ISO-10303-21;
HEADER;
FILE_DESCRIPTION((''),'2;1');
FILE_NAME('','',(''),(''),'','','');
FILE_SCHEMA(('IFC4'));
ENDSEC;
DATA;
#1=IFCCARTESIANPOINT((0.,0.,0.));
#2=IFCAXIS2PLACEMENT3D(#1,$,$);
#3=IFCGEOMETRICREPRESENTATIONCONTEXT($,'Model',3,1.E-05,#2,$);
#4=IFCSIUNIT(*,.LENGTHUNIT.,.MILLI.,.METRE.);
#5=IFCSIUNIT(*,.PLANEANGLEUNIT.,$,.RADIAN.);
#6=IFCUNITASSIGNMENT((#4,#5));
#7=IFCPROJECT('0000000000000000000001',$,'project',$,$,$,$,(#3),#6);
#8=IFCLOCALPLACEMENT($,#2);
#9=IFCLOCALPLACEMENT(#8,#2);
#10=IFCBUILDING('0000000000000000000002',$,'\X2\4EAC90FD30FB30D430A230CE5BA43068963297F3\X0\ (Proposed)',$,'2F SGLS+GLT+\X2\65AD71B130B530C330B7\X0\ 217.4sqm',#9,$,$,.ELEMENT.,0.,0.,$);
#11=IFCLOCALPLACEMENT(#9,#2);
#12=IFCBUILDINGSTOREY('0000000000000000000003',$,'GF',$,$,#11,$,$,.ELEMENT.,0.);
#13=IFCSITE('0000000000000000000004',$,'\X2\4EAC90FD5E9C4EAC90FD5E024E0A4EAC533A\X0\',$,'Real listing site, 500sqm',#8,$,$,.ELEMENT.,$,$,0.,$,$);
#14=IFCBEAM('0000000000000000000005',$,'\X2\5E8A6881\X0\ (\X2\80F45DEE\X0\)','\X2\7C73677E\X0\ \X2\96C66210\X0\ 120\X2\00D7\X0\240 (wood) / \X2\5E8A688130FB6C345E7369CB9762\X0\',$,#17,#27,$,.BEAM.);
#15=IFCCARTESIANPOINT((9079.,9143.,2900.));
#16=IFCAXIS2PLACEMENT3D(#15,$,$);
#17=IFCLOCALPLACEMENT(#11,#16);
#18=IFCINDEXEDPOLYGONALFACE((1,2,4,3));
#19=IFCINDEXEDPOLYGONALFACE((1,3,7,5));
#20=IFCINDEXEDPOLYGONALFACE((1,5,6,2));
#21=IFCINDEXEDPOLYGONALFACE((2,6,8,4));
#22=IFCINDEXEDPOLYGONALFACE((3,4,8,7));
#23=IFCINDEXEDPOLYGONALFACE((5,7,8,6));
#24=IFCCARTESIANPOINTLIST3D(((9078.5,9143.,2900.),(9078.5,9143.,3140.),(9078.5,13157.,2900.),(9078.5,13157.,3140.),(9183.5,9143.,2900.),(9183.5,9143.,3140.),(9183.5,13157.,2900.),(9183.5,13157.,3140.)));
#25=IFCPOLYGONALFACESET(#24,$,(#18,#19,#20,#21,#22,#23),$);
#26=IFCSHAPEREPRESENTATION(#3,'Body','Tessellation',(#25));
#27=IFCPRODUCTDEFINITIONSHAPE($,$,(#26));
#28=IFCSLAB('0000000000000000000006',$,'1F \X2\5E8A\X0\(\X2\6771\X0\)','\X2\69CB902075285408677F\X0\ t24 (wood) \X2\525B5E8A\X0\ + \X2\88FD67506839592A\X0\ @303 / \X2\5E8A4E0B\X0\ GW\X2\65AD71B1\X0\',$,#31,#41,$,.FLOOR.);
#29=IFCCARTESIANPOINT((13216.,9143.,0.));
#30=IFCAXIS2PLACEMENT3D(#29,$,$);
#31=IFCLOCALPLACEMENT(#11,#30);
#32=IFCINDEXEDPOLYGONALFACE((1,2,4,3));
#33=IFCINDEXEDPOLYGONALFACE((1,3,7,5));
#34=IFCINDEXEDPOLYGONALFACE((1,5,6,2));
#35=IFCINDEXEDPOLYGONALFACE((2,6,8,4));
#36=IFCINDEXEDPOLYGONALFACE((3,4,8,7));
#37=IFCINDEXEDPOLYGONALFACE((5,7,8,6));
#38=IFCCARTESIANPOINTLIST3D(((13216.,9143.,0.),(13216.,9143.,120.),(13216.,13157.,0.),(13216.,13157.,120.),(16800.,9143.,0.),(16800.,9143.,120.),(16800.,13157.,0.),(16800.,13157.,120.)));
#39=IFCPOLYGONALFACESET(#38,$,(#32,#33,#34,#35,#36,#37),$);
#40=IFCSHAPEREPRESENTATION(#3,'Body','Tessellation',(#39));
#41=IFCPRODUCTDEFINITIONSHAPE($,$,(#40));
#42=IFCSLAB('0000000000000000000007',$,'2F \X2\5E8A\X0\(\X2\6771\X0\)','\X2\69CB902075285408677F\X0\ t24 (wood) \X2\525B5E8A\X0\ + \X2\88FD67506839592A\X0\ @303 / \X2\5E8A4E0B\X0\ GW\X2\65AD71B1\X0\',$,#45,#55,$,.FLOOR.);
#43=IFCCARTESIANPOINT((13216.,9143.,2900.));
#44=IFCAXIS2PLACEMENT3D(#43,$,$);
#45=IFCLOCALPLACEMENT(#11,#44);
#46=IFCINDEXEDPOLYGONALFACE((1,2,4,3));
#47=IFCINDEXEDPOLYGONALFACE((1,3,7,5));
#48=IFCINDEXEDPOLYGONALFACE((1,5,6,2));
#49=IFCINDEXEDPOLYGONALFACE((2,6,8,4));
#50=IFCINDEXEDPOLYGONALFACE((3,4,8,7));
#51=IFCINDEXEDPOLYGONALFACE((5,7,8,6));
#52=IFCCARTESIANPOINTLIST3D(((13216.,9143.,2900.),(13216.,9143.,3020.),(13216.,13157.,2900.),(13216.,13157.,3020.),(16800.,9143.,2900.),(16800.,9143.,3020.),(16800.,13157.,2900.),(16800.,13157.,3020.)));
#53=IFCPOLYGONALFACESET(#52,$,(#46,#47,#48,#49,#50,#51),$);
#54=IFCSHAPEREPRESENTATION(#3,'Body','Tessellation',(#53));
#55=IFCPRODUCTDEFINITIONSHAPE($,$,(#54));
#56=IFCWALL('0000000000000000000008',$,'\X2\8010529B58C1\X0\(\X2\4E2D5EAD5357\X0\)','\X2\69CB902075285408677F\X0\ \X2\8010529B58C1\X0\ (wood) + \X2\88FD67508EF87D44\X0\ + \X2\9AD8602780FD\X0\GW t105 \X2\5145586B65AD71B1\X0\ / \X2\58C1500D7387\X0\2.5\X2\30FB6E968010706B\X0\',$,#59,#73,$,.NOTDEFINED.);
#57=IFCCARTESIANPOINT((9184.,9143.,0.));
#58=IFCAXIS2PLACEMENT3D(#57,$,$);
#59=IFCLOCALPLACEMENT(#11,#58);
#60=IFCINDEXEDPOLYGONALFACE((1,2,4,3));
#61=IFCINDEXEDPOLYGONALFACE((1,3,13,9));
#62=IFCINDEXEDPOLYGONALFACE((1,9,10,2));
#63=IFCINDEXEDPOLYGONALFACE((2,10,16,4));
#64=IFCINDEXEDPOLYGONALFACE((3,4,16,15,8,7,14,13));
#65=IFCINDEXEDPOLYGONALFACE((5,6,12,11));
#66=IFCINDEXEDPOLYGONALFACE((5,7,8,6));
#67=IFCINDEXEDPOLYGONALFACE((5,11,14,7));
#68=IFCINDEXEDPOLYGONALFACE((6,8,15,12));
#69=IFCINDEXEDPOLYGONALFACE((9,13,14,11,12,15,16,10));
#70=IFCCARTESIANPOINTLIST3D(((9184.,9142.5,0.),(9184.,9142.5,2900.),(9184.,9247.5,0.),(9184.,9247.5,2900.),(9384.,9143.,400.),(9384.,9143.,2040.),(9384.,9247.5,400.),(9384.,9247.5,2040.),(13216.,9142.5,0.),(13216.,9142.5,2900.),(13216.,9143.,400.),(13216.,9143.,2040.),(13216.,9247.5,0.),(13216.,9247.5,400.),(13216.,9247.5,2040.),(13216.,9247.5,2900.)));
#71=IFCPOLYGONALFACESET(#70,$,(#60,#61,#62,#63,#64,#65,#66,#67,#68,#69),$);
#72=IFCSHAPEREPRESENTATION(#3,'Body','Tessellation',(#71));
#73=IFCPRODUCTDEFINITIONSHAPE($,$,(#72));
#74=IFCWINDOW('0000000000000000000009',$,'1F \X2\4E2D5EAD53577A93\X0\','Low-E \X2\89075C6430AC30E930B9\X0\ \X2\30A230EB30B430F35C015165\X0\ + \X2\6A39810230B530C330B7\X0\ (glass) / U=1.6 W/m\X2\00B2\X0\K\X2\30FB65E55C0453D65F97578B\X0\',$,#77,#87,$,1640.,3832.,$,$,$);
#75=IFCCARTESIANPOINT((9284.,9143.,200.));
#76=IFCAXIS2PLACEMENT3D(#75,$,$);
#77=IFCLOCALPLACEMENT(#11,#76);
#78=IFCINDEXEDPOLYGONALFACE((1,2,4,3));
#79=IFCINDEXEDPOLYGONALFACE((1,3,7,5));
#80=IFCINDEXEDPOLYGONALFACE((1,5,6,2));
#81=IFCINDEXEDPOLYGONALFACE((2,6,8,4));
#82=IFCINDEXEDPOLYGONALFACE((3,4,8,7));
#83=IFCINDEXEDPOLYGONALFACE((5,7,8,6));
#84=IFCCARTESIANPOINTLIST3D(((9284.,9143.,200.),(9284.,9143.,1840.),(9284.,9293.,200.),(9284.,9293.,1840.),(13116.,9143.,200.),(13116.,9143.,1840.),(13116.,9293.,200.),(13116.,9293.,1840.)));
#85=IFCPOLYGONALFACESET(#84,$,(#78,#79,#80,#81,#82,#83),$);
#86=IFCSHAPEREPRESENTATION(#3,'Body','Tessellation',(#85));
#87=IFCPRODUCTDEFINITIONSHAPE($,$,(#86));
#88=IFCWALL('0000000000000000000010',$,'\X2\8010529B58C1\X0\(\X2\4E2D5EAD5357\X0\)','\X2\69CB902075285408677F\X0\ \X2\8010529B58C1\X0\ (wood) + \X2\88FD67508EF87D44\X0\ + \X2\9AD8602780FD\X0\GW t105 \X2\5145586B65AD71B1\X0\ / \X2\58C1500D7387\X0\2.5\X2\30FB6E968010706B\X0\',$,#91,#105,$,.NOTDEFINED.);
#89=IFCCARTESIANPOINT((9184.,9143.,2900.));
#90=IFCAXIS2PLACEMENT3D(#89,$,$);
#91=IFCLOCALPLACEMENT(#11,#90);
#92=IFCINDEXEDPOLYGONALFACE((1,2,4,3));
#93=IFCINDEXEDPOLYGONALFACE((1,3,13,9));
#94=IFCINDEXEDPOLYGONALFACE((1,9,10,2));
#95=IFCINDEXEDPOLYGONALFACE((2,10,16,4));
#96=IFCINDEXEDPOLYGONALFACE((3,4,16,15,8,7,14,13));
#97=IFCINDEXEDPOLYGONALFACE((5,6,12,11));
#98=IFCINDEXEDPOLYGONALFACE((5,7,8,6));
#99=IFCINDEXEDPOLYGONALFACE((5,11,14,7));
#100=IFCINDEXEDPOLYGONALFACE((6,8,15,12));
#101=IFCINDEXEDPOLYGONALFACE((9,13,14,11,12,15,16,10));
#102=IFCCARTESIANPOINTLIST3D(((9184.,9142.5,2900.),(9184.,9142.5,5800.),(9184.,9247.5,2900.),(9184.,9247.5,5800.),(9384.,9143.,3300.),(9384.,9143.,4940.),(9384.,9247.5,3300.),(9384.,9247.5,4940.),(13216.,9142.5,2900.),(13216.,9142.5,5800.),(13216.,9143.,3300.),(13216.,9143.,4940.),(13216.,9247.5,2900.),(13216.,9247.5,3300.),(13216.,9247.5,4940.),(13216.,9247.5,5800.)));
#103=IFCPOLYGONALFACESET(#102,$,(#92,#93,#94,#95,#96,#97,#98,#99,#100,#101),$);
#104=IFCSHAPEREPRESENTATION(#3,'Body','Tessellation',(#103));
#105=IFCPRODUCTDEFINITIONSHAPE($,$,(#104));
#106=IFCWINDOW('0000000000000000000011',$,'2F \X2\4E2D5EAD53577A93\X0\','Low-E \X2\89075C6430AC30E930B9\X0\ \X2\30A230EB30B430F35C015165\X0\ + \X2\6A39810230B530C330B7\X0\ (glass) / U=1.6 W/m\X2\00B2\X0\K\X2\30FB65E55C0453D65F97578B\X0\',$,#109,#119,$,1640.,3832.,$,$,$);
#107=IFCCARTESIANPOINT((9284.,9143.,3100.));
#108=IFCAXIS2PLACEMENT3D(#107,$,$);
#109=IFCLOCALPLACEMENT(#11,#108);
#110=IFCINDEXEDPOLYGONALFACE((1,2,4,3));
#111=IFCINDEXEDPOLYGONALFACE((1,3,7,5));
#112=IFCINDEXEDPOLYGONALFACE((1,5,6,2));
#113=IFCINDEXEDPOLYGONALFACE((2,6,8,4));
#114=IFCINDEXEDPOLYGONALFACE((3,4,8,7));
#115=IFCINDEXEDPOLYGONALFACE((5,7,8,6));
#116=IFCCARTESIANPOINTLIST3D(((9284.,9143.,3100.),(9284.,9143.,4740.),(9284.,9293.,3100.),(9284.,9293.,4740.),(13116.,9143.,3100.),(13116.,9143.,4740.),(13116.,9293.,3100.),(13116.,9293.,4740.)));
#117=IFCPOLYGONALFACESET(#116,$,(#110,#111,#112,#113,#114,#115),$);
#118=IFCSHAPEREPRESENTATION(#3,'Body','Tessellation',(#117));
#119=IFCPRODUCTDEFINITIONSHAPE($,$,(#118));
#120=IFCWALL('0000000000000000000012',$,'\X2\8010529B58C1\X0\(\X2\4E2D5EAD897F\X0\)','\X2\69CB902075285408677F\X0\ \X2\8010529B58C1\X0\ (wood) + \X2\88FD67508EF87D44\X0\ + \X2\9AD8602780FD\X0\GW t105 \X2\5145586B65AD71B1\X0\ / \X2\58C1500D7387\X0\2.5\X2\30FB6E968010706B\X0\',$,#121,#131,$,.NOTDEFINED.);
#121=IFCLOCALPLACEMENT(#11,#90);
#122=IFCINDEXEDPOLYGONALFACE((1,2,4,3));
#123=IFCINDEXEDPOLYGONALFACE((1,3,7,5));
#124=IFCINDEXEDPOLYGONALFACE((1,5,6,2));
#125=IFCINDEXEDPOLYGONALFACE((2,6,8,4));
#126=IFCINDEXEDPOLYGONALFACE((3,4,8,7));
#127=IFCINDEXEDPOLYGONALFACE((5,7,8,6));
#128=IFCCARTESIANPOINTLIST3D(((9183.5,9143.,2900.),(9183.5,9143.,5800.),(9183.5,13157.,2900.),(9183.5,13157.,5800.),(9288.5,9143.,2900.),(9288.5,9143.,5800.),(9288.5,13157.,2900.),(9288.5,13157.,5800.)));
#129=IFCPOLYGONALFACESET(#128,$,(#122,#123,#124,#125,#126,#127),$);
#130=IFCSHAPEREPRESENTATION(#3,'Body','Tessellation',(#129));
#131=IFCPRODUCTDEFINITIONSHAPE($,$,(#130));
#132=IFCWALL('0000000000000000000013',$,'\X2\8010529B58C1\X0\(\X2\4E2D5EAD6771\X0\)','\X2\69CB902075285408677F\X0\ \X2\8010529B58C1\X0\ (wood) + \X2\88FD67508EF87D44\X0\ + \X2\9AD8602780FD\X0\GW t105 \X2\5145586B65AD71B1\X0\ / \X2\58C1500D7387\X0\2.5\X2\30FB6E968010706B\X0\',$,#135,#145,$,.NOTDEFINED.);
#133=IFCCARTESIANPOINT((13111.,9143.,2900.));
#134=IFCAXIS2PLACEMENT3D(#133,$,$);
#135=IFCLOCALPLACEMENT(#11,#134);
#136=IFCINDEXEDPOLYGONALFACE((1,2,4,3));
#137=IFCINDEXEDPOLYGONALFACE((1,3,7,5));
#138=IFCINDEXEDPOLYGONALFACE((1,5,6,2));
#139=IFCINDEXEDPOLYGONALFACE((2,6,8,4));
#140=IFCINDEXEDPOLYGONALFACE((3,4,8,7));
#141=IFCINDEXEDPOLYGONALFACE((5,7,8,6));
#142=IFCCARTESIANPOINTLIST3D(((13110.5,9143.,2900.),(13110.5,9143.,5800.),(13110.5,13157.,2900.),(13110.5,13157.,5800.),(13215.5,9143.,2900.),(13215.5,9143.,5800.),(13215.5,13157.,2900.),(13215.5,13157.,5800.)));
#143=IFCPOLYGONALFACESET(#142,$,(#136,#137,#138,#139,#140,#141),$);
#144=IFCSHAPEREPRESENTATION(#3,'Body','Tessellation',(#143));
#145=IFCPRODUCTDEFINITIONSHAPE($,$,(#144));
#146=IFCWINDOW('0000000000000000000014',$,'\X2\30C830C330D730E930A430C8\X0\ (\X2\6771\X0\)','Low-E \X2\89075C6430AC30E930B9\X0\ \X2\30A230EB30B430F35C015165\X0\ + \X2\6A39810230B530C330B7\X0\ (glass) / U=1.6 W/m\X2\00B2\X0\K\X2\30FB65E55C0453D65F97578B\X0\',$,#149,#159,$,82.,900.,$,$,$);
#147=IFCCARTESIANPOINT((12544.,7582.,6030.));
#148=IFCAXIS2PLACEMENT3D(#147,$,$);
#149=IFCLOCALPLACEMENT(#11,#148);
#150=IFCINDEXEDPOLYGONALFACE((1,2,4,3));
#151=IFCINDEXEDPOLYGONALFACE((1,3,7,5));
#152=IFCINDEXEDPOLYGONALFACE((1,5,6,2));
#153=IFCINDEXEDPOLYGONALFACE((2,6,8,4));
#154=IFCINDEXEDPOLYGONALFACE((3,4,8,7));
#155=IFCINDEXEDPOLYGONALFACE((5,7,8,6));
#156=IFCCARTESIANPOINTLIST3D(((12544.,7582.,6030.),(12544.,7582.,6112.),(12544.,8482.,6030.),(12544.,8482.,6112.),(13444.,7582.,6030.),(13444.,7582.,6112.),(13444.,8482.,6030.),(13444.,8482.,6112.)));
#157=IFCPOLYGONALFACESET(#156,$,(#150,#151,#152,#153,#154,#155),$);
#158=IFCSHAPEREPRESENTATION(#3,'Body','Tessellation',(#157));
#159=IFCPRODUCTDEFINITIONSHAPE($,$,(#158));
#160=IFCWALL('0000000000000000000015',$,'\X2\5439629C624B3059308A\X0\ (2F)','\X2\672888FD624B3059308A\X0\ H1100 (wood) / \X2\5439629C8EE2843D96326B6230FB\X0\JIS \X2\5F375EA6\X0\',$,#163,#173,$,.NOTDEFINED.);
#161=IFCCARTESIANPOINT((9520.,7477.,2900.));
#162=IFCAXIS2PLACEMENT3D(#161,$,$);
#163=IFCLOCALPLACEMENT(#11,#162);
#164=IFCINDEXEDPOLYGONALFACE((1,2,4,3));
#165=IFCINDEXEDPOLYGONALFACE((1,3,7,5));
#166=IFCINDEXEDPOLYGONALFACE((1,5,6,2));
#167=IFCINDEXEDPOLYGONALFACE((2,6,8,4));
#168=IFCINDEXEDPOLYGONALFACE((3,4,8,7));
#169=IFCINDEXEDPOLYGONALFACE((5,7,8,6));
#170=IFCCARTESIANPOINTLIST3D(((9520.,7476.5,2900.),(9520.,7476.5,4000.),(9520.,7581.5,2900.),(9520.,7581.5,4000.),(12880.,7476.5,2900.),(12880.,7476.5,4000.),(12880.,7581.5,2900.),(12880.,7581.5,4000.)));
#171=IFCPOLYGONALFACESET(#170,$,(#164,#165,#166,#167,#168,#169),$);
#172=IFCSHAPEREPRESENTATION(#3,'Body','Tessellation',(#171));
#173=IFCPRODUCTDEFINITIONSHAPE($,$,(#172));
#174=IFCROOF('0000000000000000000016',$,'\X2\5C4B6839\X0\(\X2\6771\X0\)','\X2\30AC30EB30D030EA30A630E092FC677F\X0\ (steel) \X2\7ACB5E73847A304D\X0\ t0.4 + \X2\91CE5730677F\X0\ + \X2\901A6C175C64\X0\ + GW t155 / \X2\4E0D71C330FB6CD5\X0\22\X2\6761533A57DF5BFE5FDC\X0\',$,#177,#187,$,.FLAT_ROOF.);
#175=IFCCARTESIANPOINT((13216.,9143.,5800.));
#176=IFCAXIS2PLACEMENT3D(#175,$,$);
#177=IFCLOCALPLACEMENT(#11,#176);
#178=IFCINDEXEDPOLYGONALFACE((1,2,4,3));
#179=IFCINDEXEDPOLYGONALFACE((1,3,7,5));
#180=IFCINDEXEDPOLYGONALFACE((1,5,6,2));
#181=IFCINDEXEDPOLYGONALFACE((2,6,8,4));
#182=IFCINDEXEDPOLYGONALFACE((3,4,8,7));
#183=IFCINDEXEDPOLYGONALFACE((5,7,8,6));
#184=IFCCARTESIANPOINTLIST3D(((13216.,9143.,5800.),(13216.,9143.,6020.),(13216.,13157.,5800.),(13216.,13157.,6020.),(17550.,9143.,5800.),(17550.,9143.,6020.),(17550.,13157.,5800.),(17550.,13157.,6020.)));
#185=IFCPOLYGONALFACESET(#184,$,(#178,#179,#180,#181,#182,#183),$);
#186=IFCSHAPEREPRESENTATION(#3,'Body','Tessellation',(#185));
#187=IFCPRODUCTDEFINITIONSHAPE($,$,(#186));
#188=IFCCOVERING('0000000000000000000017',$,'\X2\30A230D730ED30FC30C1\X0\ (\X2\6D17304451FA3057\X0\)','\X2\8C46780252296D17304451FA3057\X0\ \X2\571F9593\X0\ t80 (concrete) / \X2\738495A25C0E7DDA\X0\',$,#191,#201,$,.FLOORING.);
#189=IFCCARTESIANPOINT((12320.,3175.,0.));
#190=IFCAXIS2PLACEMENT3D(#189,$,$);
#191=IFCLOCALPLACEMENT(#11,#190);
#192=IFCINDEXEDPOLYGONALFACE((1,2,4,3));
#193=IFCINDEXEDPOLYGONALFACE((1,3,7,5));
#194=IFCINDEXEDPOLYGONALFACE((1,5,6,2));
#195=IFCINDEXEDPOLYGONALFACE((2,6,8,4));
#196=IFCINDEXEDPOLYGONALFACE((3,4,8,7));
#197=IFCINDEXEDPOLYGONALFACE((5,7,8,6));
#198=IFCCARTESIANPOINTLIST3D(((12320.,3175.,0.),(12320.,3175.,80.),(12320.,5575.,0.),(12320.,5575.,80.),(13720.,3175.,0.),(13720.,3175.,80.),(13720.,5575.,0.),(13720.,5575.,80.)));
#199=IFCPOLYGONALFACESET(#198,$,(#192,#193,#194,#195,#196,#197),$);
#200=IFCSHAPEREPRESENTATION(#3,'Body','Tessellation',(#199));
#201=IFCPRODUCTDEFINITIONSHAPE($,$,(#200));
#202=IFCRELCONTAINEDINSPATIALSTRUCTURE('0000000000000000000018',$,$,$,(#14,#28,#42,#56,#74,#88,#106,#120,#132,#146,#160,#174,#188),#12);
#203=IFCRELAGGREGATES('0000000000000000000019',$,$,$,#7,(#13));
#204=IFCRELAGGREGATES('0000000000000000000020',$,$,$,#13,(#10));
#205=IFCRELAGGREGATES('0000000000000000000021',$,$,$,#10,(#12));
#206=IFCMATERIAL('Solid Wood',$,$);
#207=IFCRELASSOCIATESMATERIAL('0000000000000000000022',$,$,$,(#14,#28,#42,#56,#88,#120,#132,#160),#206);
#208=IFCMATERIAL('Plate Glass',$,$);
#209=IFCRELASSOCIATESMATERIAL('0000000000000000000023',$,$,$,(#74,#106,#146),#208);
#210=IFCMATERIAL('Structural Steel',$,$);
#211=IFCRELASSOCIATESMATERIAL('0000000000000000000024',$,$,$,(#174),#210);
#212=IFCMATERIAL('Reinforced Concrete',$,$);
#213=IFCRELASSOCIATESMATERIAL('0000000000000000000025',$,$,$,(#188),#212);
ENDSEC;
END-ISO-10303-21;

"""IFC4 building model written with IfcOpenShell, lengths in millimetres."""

from ifc_helpers import new_model, si_unit, frame, frame_2d, origin, place, context, project, spatial, rectangle, extrude, material, element, fill, save


model = new_model("IFC4")

# Units and contexts
model_context = context("Model", 3, precision=1e-05, world=origin())
ifc_project = project(units=[si_unit("LENGTHUNIT", "METRE", prefix="MILLI"), si_unit("PLANEANGLEUNIT", "RADIAN")], contexts=[model_context])

# Site, building, storey
site_placement = place(None, origin())
site = spatial("IfcSite", under=ifc_project, at=site_placement, Name="京都府京都市上京区", ObjectType="Real listing site, 500sqm", CompositionType="ELEMENT", RefElevation=0.0)
building_placement = place(site_placement, origin())
building = spatial("IfcBuilding", under=site, at=building_placement, Name="京都・ピアノ室と防音 (Proposed)", ObjectType="2F SGLS+GLT+断熱サッシ 217.4sqm", CompositionType="ELEMENT", ElevationOfRefHeight=0.0, ElevationOfTerrain=0.0)
storey_placement = place(building_placement, origin())
storey = spatial("IfcBuildingStorey", under=building, at=storey_placement, Name="GF", CompositionType="ELEMENT", Elevation=0.0)

# Shared definitions
ifc_material_1 = material(Name="Solid Wood")

# Beam
beam_placement = place(storey_placement, frame((9079.0, 9143.0, 2900.0)))
element("IfcBeam", 1, at=beam_placement, inside=storey, material=ifc_material_1, Name="床梁 (胴差)", Description="米松 集成 120×240 (wood) / 床梁・水平構面", PredefinedType="BEAM", context=model_context, shape_type="SweptSolid", body=[
    extrude(rectangle(XDim=105.0, YDim=4014.0, at=frame_2d((52.0, 2007.0))), frame((9079.0, 9143.0, 2900.0)), (0.0, 0.0, 1.0), 240.0),
])

# Slabs
slab_1_placement = place(storey_placement, frame((13216.0, 9143.0, 0.0)))
element("IfcSlab", 2, at=slab_1_placement, inside=storey, material=ifc_material_1, Name="1F 床(東)", Description="構造用合板 t24 (wood) 剛床 + 製材根太 @303 / 床下 GW断熱", PredefinedType="FLOOR", context=model_context, shape_type="SweptSolid", body=[
    extrude(rectangle(XDim=3584.0, YDim=4014.0, at=frame_2d((1792.0, 2007.0))), frame((13216.0, 9143.0, 0.0)), (0.0, 0.0, 1.0), 120.0),
])
slab_2_placement = place(storey_placement, frame((13216.0, 9143.0, 2900.0)))
element("IfcSlab", 3, at=slab_2_placement, inside=storey, material=ifc_material_1, Name="2F 床(東)", Description="構造用合板 t24 (wood) 剛床 + 製材根太 @303 / 床下 GW断熱", PredefinedType="FLOOR", context=model_context, shape_type="SweptSolid", body=[
    extrude(rectangle(XDim=3584.0, YDim=4014.0, at=frame_2d((1792.0, 2007.0))), frame((13216.0, 9143.0, 2900.0)), (0.0, 0.0, 1.0), 120.0),
])

# Wall, opening, window
wall_1_placement = place(storey_placement, frame((9184.0, 9143.0, 0.0)))
wall_1 = element("IfcWall", 4, at=wall_1_placement, inside=storey, material=ifc_material_1, Name="耐力壁(中庭南)", Description="構造用合板 耐力壁 (wood) + 製材軸組 + 高性能GW t105 充填断熱 / 壁倍率2.5・準耐火", PredefinedType="NOTDEFINED", context=model_context, shape_type="SweptSolid", body=[
    extrude(rectangle(XDim=4032.0, YDim=105.0, at=frame_2d((2016.0, 52.0))), frame((9184.0, 9143.0, 0.0)), (0.0, 0.0, 1.0), 2900.0),
])
opening_1_placement = place(storey_placement, frame((9284.0, 9143.0, 200.0)))
opening_1 = element("IfcOpeningElement", 5, at=opening_1_placement, cuts=wall_1, PredefinedType="NOTDEFINED", context=model_context, shape_type="SweptSolid", body=[
    extrude(rectangle(XDim=3832.0, YDim=150.0, at=frame_2d((1916.0, 75.0))), frame((9284.0, 9143.0, 200.0)), (0.0, 0.0, 1.0), 1640.0),
])
ifc_material_2 = material(Name="Plate Glass")
window_1_placement = place(storey_placement, frame((9284.0, 9143.0, 200.0)))
window_1 = element("IfcWindow", 6, at=window_1_placement, inside=storey, material=ifc_material_2, Name="1F 中庭南窓", Description="Low-E 複層ガラス アルゴン封入 + 樹脂サッシ (glass) / U=1.6 W/m²K・日射取得型", OverallHeight=1640.0, OverallWidth=3832.0, context=model_context, shape_type="SweptSolid", body=[
    extrude(rectangle(XDim=3832.0, YDim=150.0, at=frame_2d((1916.0, 75.0))), frame((9284.0, 9143.0, 200.0)), (0.0, 0.0, 1.0), 1640.0),
])
fill(opening_1, window_1)

# Wall, opening, window
wall_2_placement = place(storey_placement, frame((9184.0, 9143.0, 2900.0)))
wall_2 = element("IfcWall", 7, at=wall_2_placement, inside=storey, material=ifc_material_1, Name="耐力壁(中庭南)", Description="構造用合板 耐力壁 (wood) + 製材軸組 + 高性能GW t105 充填断熱 / 壁倍率2.5・準耐火", PredefinedType="NOTDEFINED", context=model_context, shape_type="SweptSolid", body=[
    extrude(rectangle(XDim=4032.0, YDim=105.0, at=frame_2d((2016.0, 52.0))), frame((9184.0, 9143.0, 2900.0)), (0.0, 0.0, 1.0), 2900.0),
])
opening_2_placement = place(storey_placement, frame((9284.0, 9143.0, 3100.0)))
opening_2 = element("IfcOpeningElement", 8, at=opening_2_placement, cuts=wall_2, PredefinedType="NOTDEFINED", context=model_context, shape_type="SweptSolid", body=[
    extrude(rectangle(XDim=3832.0, YDim=150.0, at=frame_2d((1916.0, 75.0))), frame((9284.0, 9143.0, 3100.0)), (0.0, 0.0, 1.0), 1640.0),
])
window_2_placement = place(storey_placement, frame((9284.0, 9143.0, 3100.0)))
window_2 = element("IfcWindow", 9, at=window_2_placement, inside=storey, material=ifc_material_2, Name="2F 中庭南窓", Description="Low-E 複層ガラス アルゴン封入 + 樹脂サッシ (glass) / U=1.6 W/m²K・日射取得型", OverallHeight=1640.0, OverallWidth=3832.0, context=model_context, shape_type="SweptSolid", body=[
    extrude(rectangle(XDim=3832.0, YDim=150.0, at=frame_2d((1916.0, 75.0))), frame((9284.0, 9143.0, 3100.0)), (0.0, 0.0, 1.0), 1640.0),
])
fill(opening_2, window_2)

# Walls
wall_3_placement = place(storey_placement, frame((9184.0, 9143.0, 2900.0)))
element("IfcWall", 10, at=wall_3_placement, inside=storey, material=ifc_material_1, Name="耐力壁(中庭西)", Description="構造用合板 耐力壁 (wood) + 製材軸組 + 高性能GW t105 充填断熱 / 壁倍率2.5・準耐火", PredefinedType="NOTDEFINED", context=model_context, shape_type="SweptSolid", body=[
    extrude(rectangle(XDim=105.0, YDim=4014.0, at=frame_2d((52.0, 2007.0))), frame((9184.0, 9143.0, 2900.0)), (0.0, 0.0, 1.0), 2900.0),
])
wall_4_placement = place(storey_placement, frame((13111.0, 9143.0, 2900.0)))
element("IfcWall", 11, at=wall_4_placement, inside=storey, material=ifc_material_1, Name="耐力壁(中庭東)", Description="構造用合板 耐力壁 (wood) + 製材軸組 + 高性能GW t105 充填断熱 / 壁倍率2.5・準耐火", PredefinedType="NOTDEFINED", context=model_context, shape_type="SweptSolid", body=[
    extrude(rectangle(XDim=105.0, YDim=4014.0, at=frame_2d((52.0, 2007.0))), frame((13111.0, 9143.0, 2900.0)), (0.0, 0.0, 1.0), 2900.0),
])

# Window
window_3_placement = place(storey_placement, frame((12544.0, 7582.0, 6030.0)))
element("IfcWindow", 12, at=window_3_placement, inside=storey, material=ifc_material_2, Name="トップライト (東)", Description="Low-E 複層ガラス アルゴン封入 + 樹脂サッシ (glass) / U=1.6 W/m²K・日射取得型", OverallHeight=82.0, OverallWidth=900.0, context=model_context, shape_type="SweptSolid", body=[
    extrude(rectangle(XDim=900.0, YDim=900.0, at=frame_2d((450.0, 450.0))), frame((12544.0, 7582.0, 6030.0)), (0.0, 0.0, 1.0), 82.0),
])

# Wall
wall_5_placement = place(storey_placement, frame((9520.0, 7477.0, 2900.0)))
element("IfcWall", 13, at=wall_5_placement, inside=storey, material=ifc_material_1, Name="吹抜手すり (2F)", Description="木製手すり H1100 (wood) / 吹抜転落防止・JIS 強度", PredefinedType="NOTDEFINED", context=model_context, shape_type="SweptSolid", body=[
    extrude(rectangle(XDim=3360.0, YDim=105.0, at=frame_2d((1680.0, 52.0))), frame((9520.0, 7477.0, 2900.0)), (0.0, 0.0, 1.0), 1100.0),
])

# Roof
ifc_material_3 = material(Name="Structural Steel")
roof_placement = place(storey_placement, frame((13216.0, 9143.0, 5800.0)))
element("IfcRoof", 14, at=roof_placement, inside=storey, material=ifc_material_3, Name="屋根(東)", Description="ガルバリウム鋼板 (steel) 立平葺き t0.4 + 野地板 + 通気層 + GW t155 / 不燃・法22条区域対応", PredefinedType="FLAT_ROOF", context=model_context, shape_type="SweptSolid", body=[
    extrude(rectangle(XDim=4334.0, YDim=4014.0, at=frame_2d((2167.0, 2007.0))), frame((13216.0, 9143.0, 5800.0)), (0.0, 0.0, 1.0), 220.0),
])

# Covering
ifc_material_4 = material(Name="Reinforced Concrete")
covering_placement = place(storey_placement, frame((12320.0, 3175.0, 0.0)))
element("IfcCovering", 15, at=covering_placement, inside=storey, material=ifc_material_4, Name="アプローチ (洗い出し)", Description="豆砂利洗い出し 土間 t80 (concrete) / 玄関導線", PredefinedType="FLOORING", context=model_context, shape_type="SweptSolid", body=[
    extrude(rectangle(XDim=1400.0, YDim=2400.0, at=frame_2d((700.0, 1200.0))), frame((12320.0, 3175.0, 0.0)), (0.0, 0.0, 1.0), 80.0),
])

save(model, "model.ifc")
